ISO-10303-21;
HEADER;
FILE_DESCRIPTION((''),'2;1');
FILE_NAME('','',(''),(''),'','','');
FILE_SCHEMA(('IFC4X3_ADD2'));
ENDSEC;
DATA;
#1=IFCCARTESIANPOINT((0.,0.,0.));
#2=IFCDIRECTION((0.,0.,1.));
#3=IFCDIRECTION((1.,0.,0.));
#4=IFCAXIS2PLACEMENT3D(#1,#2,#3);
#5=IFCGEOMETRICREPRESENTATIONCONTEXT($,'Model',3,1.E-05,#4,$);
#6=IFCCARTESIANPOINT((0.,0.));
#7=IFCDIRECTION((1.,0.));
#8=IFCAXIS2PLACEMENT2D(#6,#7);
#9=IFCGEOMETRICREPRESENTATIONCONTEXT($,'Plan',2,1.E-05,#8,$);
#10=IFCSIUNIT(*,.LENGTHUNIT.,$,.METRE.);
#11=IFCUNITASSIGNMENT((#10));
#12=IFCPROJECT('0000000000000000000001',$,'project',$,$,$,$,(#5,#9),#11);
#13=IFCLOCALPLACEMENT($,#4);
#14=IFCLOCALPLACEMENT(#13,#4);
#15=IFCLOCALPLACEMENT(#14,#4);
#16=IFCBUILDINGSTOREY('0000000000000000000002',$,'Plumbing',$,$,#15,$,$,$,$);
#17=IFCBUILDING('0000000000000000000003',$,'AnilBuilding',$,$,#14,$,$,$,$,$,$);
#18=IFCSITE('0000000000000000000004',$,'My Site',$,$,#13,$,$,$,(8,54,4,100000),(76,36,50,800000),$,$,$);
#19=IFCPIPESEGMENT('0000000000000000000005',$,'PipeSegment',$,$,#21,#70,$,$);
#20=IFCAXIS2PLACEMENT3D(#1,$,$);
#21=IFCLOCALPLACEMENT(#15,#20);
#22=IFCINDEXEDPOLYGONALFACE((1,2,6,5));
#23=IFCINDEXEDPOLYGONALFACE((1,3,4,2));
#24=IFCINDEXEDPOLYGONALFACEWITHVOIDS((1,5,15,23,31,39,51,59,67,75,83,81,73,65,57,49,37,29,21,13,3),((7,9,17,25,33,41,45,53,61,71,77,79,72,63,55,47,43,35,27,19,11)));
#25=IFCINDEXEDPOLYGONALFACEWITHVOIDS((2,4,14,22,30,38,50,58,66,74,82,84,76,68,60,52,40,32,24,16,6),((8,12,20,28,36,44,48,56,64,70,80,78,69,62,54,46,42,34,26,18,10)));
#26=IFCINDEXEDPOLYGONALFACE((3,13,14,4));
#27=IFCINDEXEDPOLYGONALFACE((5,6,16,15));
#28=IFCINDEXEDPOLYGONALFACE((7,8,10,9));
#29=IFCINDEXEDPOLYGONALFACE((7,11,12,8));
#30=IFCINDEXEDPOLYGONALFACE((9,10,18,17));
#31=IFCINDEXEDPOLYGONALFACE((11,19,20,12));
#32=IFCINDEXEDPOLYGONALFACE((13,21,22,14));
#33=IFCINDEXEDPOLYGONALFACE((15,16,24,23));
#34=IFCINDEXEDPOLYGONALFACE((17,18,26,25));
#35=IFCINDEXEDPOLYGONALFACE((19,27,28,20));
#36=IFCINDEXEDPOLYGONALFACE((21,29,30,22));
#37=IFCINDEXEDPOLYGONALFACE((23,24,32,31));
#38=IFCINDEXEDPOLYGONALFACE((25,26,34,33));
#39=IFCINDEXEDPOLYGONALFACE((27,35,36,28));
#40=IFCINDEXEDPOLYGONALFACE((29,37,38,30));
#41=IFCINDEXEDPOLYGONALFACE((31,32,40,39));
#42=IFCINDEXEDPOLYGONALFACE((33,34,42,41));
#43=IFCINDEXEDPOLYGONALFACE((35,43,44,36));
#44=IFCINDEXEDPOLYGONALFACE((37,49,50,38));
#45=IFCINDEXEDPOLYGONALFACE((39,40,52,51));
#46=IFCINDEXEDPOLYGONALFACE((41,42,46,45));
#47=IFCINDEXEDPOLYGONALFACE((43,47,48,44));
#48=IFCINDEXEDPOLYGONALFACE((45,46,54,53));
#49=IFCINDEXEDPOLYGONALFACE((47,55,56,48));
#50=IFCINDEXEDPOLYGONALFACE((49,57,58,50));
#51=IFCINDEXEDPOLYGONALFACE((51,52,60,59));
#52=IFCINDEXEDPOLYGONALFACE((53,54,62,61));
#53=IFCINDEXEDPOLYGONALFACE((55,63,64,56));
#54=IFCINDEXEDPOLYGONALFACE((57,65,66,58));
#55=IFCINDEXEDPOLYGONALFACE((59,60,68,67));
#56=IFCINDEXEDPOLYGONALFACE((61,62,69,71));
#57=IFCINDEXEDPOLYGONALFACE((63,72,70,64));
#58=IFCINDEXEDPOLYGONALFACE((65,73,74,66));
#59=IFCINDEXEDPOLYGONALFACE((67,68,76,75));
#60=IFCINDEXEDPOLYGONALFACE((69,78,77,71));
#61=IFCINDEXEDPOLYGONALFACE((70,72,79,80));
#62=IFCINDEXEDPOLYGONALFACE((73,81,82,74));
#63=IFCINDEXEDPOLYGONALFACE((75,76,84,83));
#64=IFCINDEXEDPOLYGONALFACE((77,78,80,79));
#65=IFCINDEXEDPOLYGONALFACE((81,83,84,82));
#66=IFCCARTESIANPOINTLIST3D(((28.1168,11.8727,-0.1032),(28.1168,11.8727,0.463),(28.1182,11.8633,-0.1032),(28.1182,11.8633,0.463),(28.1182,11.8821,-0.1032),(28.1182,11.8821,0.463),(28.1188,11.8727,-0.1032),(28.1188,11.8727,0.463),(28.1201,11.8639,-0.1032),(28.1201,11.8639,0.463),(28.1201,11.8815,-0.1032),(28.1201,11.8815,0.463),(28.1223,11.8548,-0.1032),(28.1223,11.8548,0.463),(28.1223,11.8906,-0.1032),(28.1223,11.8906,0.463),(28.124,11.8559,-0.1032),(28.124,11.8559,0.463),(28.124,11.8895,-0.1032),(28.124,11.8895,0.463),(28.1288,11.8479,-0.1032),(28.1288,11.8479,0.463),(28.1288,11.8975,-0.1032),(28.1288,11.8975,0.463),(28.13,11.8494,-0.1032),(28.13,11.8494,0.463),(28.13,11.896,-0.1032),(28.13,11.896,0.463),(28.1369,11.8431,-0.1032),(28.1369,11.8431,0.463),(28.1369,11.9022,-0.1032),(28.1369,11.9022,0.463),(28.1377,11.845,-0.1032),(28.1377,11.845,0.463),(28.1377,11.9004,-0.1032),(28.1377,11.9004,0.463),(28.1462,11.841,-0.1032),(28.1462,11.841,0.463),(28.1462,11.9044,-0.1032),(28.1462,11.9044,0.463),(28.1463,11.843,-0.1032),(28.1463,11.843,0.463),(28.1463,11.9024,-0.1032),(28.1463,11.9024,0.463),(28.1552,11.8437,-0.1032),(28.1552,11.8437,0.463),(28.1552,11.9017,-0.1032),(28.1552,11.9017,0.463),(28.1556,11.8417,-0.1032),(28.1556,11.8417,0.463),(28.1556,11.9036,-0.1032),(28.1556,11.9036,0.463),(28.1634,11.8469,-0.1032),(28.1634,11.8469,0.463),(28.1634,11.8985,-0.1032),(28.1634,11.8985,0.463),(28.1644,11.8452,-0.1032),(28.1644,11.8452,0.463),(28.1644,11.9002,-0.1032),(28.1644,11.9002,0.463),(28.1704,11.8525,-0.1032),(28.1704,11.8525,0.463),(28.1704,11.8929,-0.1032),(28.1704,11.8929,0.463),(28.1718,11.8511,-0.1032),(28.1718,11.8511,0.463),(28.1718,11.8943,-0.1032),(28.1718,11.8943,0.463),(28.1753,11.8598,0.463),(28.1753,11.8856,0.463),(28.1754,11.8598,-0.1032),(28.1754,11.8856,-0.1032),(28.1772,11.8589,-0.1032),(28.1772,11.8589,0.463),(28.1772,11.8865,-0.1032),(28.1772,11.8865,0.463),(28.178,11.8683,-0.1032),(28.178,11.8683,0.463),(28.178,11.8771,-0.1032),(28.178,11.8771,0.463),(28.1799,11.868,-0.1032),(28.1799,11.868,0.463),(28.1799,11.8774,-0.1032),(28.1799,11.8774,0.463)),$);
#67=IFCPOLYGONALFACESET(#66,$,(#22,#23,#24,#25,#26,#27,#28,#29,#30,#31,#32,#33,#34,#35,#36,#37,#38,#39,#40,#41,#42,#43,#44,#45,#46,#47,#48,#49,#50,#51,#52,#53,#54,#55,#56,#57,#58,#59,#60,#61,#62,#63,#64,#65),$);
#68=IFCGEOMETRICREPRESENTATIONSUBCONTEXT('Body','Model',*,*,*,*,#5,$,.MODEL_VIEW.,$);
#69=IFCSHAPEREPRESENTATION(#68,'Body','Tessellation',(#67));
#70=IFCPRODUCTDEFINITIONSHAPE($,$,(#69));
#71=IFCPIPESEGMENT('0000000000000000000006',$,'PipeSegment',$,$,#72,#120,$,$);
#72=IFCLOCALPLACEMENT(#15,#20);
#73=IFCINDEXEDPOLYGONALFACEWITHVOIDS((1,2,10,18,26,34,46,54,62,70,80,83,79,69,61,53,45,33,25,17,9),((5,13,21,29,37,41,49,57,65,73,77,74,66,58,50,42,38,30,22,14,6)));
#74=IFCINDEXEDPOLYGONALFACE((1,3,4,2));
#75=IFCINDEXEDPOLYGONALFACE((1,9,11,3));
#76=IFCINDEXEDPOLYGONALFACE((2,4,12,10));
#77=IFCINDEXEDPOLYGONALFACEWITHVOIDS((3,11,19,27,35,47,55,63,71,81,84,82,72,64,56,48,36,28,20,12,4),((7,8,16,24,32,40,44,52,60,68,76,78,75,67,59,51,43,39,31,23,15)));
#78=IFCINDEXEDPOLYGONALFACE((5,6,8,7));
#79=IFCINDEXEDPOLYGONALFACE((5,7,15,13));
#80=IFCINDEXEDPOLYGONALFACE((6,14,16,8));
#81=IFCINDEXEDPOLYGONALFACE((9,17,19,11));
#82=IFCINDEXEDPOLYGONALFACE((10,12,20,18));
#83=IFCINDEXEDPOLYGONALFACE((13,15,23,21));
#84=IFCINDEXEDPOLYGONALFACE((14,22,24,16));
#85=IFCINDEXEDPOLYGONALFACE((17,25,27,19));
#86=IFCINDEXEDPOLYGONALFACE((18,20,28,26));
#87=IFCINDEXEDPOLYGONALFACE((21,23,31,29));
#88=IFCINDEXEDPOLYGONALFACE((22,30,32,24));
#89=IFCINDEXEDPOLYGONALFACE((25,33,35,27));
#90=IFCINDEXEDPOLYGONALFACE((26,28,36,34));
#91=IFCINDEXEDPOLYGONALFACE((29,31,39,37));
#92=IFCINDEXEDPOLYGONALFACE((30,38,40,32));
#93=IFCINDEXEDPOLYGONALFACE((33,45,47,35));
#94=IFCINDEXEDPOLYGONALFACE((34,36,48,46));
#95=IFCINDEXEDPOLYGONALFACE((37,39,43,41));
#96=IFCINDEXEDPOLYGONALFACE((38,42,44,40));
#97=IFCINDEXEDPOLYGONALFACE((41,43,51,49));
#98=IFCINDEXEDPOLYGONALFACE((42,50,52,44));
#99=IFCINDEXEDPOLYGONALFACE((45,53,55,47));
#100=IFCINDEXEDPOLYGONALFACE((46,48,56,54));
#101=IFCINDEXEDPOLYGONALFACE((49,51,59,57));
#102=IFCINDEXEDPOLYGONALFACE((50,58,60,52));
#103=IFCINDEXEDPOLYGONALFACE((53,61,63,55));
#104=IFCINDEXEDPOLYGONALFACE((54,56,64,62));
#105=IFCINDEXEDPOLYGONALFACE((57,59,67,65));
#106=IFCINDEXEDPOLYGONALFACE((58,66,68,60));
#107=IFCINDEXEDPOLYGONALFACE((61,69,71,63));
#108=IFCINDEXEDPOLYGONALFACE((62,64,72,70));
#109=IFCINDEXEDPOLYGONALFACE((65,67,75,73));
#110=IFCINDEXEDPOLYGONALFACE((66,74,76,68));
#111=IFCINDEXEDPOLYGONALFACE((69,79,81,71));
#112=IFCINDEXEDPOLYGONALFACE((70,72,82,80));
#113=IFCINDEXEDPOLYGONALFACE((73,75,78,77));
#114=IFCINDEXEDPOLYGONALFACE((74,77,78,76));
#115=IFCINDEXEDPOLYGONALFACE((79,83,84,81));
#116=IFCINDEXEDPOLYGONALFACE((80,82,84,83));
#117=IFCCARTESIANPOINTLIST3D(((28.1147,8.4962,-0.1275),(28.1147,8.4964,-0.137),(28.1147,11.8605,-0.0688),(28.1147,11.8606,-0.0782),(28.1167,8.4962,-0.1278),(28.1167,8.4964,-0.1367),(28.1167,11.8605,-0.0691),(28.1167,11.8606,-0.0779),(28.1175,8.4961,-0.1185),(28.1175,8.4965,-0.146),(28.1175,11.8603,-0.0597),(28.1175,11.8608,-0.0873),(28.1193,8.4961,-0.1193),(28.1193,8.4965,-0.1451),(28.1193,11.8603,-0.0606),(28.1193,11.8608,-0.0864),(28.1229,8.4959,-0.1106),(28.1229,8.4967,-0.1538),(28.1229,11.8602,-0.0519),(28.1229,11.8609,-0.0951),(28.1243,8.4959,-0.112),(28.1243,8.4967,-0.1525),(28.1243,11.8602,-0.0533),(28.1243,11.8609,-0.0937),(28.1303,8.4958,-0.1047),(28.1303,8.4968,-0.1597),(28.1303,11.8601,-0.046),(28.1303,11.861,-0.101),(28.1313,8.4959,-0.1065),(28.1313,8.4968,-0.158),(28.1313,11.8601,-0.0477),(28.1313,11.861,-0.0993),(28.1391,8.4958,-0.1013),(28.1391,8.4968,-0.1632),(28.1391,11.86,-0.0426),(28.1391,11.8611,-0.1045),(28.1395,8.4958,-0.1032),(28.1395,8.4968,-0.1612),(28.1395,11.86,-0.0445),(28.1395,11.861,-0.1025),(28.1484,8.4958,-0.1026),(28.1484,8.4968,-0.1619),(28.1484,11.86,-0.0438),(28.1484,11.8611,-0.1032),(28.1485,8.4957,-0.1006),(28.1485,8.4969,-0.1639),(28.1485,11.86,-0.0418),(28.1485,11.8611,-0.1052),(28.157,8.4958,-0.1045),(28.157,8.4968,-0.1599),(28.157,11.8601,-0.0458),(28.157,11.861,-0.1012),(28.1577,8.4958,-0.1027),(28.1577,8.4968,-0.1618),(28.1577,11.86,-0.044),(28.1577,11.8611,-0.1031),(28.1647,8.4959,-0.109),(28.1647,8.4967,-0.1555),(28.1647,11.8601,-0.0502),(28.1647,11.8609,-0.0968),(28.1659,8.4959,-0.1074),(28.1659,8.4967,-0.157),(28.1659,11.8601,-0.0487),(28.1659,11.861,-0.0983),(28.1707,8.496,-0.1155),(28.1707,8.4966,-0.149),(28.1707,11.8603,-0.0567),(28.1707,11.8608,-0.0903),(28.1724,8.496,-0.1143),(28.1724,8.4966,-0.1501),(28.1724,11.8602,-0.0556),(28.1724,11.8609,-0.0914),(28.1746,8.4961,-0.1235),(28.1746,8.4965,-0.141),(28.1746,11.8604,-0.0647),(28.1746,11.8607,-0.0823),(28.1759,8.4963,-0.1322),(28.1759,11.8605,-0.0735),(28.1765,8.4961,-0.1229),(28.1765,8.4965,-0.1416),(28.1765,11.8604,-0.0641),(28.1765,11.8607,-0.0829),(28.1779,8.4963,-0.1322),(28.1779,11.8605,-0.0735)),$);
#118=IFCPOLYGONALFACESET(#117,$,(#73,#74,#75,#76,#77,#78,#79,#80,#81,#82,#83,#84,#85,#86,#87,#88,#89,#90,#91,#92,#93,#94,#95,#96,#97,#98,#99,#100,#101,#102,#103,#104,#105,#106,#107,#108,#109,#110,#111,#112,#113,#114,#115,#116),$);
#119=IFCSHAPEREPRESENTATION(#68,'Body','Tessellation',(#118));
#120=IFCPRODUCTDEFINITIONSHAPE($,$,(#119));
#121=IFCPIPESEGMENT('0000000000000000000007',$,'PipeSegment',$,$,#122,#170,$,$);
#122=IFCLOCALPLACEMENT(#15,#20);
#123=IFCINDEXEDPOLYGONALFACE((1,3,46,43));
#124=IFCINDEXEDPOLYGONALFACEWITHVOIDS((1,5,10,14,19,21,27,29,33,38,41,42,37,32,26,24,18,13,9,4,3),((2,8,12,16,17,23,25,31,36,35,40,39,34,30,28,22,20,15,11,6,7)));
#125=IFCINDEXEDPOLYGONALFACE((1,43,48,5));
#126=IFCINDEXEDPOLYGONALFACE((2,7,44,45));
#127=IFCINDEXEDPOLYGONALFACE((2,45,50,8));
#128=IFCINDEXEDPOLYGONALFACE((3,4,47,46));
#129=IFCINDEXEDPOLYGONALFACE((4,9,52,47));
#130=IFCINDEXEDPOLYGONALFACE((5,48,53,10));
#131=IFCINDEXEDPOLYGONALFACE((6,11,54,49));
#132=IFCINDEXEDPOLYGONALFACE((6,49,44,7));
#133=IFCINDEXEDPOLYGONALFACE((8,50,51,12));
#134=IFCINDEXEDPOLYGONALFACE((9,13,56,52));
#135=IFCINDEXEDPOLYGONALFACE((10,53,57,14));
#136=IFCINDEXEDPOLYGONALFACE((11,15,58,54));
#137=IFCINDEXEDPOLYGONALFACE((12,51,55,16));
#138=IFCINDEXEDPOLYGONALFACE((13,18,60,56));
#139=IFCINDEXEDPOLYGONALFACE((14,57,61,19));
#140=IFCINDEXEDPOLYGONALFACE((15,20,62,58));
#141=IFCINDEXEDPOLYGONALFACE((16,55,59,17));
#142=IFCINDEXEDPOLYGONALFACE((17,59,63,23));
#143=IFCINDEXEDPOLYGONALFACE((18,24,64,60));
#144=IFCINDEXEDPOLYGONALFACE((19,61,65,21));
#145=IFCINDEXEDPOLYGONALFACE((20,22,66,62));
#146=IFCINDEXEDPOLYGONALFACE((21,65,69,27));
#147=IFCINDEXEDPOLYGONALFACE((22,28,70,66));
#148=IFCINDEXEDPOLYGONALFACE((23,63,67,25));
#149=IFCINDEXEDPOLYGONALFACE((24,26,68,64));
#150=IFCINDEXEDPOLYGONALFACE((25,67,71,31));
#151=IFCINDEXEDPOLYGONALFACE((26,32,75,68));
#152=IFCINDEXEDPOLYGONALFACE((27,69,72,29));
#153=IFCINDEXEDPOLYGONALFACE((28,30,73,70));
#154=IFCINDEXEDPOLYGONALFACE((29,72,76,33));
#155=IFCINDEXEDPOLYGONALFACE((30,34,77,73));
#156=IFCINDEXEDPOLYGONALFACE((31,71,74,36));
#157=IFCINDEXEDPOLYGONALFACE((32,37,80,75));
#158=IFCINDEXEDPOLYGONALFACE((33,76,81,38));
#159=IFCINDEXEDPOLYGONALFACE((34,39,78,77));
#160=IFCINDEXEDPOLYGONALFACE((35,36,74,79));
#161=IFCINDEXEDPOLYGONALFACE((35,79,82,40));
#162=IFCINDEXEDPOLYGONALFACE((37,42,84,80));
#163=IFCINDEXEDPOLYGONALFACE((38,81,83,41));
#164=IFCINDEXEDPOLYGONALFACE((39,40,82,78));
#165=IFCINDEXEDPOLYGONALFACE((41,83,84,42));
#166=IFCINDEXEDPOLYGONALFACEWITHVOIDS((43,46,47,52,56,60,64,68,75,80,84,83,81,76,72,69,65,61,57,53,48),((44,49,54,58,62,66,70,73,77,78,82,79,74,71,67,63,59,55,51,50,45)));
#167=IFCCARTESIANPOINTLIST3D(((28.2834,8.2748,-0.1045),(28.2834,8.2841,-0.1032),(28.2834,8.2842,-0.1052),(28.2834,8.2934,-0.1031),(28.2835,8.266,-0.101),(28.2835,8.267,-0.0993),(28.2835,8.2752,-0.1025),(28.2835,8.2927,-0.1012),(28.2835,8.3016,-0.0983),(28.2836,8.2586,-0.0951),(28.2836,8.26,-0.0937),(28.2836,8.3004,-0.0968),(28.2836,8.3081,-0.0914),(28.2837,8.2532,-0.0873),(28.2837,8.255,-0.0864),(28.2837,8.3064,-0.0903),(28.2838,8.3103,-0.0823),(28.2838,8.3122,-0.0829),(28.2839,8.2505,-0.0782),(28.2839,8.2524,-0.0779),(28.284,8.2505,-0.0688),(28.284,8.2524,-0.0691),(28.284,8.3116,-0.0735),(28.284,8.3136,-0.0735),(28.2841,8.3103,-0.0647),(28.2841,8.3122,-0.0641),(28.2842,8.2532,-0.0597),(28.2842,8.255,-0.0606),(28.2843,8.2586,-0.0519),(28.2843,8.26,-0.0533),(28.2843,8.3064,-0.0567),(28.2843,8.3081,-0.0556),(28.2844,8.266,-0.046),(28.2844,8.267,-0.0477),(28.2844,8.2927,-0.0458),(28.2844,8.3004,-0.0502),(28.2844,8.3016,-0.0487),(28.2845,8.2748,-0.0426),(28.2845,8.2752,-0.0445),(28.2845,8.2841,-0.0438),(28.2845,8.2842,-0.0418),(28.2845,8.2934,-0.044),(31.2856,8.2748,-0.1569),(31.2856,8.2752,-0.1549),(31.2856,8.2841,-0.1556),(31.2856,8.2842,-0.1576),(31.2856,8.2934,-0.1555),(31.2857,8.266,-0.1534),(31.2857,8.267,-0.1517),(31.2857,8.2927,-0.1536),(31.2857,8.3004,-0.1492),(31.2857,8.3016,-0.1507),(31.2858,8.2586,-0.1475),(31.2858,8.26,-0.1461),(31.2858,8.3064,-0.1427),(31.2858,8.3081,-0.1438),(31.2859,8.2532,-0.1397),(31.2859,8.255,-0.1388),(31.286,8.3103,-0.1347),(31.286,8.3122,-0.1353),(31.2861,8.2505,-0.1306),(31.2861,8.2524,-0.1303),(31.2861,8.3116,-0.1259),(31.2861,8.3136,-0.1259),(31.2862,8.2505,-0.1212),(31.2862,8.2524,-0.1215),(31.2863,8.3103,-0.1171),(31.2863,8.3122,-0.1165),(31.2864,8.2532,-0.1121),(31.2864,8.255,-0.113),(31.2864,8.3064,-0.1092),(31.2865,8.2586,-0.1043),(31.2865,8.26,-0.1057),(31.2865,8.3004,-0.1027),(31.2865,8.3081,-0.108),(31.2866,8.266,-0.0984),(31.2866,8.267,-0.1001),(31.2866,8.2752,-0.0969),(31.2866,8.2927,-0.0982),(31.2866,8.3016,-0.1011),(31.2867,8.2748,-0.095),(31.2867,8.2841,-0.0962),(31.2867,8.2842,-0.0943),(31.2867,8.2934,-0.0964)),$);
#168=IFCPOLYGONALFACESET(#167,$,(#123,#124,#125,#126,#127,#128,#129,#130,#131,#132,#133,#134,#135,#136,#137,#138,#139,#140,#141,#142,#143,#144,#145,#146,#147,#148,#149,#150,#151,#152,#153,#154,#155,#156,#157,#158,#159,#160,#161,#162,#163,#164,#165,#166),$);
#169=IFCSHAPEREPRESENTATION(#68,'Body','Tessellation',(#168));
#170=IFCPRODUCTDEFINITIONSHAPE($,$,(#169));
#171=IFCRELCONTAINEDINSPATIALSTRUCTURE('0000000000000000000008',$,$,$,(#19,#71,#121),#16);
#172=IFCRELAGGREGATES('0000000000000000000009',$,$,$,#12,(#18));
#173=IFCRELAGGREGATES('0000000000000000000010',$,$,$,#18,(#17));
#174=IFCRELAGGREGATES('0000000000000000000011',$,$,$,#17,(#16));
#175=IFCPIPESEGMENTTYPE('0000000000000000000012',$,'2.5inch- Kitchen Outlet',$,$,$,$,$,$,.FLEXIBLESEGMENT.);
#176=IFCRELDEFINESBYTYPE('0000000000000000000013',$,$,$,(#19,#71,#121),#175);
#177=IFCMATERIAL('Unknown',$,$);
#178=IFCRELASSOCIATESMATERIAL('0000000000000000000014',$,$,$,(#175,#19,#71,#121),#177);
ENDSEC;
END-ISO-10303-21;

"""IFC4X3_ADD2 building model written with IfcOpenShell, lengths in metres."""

from ifc_helpers import new_model, si_unit, frame, origin_with_axes, origin_2d_with_axis, place, context, subcontext, project, spatial, hollow_circle, extrude, material, material_profile, profile_set, profile_usage, type_object, element, save


model = new_model("IFC4X3_ADD2")

# Units and contexts
model_context = context("Model", 3, precision=1e-05, world=origin_with_axes())
plan_context = context("Plan", 2, precision=1e-05, world=origin_2d_with_axis())
body_context = subcontext(model_context, "Body", "Model", "MODEL_VIEW")
ifc_project = project(units=[si_unit("LENGTHUNIT", "METRE")], contexts=[model_context, plan_context])

# Site, building, storey
site_placement = place(None, origin_with_axes())
site = spatial("IfcSite", under=ifc_project, at=site_placement, Name="My Site", RefLatitude=(8, 54, 4, 100000), RefLongitude=(76, 36, 50, 800000))
building_placement = place(site_placement, origin_with_axes())
building = spatial("IfcBuilding", under=site, at=building_placement, Name="AnilBuilding")
storey_placement = place(building_placement, origin_with_axes())
storey = spatial("IfcBuildingStorey", under=building, at=storey_placement, Name="Plumbing")

# Pipe segments
ifc_material_1 = material(Name="Unknown")
ifc_material_profile_1 = material_profile(ifc_material_1, hollow_circle(Radius=0.0318, WallThickness=0.002))
ifc_profile_set_1 = profile_set([ifc_material_profile_1], Name="kitchenwater")
ifc_profile_usage_1 = profile_usage(ifc_profile_set_1)
pipe_segment_type_1 = type_object("IfcPipeSegmentType", Name="2.5inch- Kitchen Outlet", PredefinedType="FLEXIBLESEGMENT", material=ifc_profile_set_1)
pipe_segment_1_placement = place(storey_placement, frame((28.1485, 11.8727, -0.1032), z_axis=(0.0, 0.0, 1.0), x_axis=(-1.0, 0.0, 0.0)))
element("IfcPipeSegment", 1, at=pipe_segment_1_placement, inside=storey, type_object=pipe_segment_type_1, material=ifc_profile_usage_1, Name="PipeSegment", context=body_context, shape_type="SweptSolid", body=[
    extrude(hollow_circle(Radius=0.0318, WallThickness=0.002), origin_with_axes(), (0.0, 0.0, 1.0), 0.5662),
])
ifc_profile_usage_2 = profile_usage(ifc_profile_set_1)
pipe_segment_2_placement = place(storey_placement, frame((28.1461, 11.8605, -0.0735), z_axis=(0.0, -0.999848, -0.017452), x_axis=(1.0, 0.0, 0.0)))
element("IfcPipeSegment", 2, at=pipe_segment_2_placement, inside=storey, type_object=pipe_segment_type_1, material=ifc_profile_usage_2, Name="PipeSegment", context=body_context, shape_type="SweptSolid", body=[
    extrude(hollow_circle(Radius=0.0318, WallThickness=0.002), origin_with_axes(), (0.0, 0.0, 1.0), 3.3648),
])
ifc_profile_usage_3 = profile_usage(ifc_profile_set_1)
pipe_segment_3_placement = place(storey_placement, frame((28.284, 8.2818, -0.0735), z_axis=(0.999848, 0.0, -0.017452), x_axis=(0.0, 1.0, 0.0)))
element("IfcPipeSegment", 3, at=pipe_segment_3_placement, inside=storey, type_object=pipe_segment_type_1, material=ifc_profile_usage_3, Name="PipeSegment", context=body_context, shape_type="SweptSolid", body=[
    extrude(hollow_circle(Radius=0.0318, WallThickness=0.002), origin_with_axes(), (0.0, 0.0, 1.0), 3.0026),
])

save(model, "model.ifc")
